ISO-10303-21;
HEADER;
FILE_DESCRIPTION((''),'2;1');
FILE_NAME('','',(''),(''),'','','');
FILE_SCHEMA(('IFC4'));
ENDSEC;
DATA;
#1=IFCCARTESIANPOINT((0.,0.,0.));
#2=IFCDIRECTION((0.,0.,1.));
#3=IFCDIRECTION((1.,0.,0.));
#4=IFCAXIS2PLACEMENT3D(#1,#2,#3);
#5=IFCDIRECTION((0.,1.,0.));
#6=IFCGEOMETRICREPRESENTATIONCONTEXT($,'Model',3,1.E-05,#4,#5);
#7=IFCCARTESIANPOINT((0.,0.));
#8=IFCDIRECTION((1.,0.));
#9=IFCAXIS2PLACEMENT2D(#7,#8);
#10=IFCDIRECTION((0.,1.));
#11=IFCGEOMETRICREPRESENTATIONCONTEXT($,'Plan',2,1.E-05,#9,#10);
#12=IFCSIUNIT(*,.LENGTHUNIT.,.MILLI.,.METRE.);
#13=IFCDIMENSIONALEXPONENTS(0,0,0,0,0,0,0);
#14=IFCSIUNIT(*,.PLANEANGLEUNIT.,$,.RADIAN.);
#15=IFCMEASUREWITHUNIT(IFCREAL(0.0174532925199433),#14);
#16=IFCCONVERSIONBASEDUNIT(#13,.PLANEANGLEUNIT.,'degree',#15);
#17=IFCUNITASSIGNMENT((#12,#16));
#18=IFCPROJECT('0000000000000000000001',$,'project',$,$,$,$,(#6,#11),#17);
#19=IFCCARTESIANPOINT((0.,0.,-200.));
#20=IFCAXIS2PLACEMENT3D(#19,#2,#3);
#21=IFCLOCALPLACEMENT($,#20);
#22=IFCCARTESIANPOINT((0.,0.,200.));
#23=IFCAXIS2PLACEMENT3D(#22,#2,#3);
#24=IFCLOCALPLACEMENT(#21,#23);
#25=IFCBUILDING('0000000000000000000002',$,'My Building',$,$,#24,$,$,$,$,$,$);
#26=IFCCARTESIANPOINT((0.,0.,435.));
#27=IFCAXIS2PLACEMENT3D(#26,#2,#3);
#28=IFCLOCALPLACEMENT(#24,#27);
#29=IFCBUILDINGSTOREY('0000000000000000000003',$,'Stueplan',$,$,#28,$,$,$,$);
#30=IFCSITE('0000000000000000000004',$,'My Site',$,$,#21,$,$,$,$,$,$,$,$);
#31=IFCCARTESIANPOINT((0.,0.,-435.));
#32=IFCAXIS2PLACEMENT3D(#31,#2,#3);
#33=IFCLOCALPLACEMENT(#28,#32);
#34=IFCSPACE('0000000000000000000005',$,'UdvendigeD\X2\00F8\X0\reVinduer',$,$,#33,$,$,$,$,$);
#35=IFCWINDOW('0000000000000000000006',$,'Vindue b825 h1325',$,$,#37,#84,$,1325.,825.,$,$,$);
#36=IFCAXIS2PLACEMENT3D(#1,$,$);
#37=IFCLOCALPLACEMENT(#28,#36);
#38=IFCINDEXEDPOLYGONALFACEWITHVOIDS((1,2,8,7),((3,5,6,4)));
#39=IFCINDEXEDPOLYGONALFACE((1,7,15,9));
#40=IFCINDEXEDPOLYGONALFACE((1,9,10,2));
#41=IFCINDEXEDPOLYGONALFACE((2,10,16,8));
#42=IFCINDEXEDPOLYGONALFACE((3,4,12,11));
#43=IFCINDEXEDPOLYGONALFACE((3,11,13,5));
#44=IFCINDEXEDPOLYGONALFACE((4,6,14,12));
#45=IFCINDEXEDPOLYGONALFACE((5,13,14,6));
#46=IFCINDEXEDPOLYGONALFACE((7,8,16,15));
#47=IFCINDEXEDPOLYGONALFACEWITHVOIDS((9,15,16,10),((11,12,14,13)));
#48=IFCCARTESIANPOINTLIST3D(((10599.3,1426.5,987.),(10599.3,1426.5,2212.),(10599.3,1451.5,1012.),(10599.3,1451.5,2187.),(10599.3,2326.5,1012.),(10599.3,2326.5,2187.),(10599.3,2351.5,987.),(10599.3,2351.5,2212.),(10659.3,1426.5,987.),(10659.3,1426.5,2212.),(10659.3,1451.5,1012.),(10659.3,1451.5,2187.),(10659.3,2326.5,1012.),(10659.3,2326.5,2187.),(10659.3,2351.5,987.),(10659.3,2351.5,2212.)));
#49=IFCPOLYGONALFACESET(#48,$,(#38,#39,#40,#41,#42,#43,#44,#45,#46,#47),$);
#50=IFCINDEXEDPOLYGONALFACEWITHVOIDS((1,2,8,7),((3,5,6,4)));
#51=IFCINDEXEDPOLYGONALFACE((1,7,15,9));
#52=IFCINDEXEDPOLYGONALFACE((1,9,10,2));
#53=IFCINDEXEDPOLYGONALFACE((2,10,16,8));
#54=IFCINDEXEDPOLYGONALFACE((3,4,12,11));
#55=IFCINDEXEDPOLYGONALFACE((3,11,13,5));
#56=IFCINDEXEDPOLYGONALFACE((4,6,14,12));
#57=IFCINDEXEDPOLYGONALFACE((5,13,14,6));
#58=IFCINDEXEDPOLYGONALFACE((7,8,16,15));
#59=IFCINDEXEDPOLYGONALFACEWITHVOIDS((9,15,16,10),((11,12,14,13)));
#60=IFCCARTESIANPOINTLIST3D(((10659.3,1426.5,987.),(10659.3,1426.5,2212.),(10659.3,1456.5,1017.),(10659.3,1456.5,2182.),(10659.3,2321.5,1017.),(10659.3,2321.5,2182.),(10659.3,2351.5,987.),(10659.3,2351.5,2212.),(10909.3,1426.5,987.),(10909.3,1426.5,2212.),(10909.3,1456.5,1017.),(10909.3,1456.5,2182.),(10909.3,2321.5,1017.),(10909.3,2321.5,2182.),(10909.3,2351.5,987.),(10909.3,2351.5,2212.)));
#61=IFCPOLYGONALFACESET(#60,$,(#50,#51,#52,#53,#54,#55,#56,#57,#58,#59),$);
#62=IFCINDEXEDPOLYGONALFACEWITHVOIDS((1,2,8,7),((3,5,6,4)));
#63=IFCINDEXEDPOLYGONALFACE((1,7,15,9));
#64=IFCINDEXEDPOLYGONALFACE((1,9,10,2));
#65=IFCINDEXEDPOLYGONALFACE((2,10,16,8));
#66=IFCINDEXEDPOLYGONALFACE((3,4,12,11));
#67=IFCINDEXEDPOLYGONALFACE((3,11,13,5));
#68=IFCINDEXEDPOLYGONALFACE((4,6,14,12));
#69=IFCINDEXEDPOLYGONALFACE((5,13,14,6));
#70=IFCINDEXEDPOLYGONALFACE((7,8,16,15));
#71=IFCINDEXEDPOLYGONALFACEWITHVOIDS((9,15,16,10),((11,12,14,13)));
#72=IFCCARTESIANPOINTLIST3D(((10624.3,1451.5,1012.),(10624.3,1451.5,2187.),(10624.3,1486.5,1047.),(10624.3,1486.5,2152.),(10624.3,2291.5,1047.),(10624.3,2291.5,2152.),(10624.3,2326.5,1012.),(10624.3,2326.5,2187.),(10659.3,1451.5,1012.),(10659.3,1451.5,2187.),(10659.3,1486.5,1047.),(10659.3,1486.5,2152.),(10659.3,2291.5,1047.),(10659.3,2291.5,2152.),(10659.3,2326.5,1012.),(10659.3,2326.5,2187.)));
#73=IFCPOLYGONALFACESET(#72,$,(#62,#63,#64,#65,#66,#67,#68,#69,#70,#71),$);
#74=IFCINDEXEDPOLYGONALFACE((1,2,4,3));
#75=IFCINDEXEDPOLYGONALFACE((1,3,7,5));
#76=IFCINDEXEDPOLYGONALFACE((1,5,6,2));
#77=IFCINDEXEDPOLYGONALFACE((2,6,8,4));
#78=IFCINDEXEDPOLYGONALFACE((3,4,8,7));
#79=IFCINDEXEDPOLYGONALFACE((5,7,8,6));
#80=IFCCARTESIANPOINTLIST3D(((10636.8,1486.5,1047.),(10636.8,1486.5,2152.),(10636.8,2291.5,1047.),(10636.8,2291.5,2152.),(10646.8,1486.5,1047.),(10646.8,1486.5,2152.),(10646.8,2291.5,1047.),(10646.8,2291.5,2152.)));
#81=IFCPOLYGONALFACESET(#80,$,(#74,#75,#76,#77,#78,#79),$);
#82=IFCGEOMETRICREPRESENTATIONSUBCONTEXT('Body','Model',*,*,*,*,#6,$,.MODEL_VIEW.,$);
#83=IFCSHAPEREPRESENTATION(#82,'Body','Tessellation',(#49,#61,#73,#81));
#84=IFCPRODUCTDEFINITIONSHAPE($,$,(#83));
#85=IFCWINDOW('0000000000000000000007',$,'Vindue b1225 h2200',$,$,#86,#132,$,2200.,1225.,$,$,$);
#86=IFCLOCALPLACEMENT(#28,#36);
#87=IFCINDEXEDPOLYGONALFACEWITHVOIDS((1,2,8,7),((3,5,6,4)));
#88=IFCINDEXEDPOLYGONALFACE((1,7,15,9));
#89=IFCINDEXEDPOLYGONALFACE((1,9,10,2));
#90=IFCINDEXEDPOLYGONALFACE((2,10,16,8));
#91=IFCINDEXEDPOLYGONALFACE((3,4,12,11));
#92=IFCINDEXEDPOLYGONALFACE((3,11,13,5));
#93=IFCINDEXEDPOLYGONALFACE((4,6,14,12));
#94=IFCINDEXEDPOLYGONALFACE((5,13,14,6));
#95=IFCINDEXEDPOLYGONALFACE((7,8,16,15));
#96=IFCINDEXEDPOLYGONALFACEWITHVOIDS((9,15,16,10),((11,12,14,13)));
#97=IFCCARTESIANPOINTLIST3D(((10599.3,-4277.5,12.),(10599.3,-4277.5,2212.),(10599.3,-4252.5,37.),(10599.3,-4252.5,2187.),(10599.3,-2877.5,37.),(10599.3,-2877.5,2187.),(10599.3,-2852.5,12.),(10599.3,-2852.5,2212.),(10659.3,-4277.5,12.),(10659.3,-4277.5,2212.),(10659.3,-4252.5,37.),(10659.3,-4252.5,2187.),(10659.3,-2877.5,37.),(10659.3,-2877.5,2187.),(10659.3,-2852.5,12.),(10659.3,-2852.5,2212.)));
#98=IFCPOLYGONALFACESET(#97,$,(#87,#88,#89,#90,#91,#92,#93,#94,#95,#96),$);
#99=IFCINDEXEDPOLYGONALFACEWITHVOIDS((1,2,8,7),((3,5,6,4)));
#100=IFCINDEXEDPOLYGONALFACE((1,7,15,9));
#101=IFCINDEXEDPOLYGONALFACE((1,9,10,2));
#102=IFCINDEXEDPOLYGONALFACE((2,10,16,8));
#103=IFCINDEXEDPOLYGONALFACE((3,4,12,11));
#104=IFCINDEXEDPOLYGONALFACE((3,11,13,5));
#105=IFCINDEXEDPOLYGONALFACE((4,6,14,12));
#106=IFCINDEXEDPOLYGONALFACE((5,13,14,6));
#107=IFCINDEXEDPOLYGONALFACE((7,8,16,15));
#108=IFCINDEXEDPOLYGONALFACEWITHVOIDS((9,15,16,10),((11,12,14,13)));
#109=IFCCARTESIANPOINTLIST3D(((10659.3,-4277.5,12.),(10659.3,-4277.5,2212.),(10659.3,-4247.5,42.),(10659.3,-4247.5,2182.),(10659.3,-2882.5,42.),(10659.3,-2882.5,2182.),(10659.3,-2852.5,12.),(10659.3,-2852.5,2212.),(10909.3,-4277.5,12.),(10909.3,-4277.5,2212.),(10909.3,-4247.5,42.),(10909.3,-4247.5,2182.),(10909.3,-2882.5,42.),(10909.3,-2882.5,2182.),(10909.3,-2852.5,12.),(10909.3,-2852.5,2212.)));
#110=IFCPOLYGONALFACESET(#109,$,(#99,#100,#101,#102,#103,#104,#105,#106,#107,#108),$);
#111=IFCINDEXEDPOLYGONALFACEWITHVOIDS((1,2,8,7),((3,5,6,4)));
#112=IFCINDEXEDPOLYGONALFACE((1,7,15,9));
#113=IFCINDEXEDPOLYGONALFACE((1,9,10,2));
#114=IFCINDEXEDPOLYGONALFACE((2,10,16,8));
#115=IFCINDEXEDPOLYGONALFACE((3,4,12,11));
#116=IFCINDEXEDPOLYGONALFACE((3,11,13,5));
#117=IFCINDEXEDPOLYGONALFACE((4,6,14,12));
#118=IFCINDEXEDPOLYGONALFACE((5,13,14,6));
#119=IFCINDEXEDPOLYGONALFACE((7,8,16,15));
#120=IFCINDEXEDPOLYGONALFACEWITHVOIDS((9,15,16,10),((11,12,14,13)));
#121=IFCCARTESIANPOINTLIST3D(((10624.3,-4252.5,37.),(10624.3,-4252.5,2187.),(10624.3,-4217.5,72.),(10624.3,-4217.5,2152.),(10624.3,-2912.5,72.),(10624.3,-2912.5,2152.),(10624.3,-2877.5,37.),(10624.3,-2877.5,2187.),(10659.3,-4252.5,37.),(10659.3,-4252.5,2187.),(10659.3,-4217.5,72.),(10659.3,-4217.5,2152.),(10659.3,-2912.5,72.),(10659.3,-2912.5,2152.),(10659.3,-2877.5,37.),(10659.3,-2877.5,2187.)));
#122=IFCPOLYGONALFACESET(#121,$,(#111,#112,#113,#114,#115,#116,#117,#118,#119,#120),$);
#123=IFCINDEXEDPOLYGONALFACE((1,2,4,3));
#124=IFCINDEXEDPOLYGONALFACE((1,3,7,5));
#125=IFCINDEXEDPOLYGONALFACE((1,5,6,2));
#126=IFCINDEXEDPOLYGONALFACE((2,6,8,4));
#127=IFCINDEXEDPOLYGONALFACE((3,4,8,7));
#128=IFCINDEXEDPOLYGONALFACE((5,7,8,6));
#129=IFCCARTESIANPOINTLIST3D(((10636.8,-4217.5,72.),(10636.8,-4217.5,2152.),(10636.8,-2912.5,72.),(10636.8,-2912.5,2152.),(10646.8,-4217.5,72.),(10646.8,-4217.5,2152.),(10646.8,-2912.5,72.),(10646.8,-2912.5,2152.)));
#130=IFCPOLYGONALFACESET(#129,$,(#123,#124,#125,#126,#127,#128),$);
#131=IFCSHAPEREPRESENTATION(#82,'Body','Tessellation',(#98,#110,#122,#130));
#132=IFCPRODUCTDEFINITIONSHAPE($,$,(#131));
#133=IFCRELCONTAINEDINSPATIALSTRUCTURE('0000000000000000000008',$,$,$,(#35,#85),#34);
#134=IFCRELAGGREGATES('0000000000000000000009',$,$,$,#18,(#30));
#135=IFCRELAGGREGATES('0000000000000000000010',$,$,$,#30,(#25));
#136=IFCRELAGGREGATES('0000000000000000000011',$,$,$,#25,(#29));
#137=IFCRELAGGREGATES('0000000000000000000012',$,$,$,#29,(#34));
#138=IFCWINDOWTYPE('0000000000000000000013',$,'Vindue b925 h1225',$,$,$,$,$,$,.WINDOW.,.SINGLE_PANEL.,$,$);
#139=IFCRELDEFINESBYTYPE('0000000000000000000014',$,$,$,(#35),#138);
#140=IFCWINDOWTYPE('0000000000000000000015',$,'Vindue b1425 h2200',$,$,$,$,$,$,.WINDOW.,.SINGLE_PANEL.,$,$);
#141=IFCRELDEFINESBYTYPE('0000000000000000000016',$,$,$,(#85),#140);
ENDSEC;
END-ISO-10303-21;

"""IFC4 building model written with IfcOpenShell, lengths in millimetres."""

from ifc_helpers import new_model, entity, si_unit, converted_unit, direction, frame, origin_with_axes, origin_2d_with_axis, place, context, subcontext, project, spatial, line, indexed_curve, outline, extrude, shape, source, transform, mapped, type_object, type_shapes, element, save


model = new_model("IFC4")

# Units and contexts
model_context = context("Model", 3, precision=1e-05, world=origin_with_axes(), true_north=direction((0.0, 1.0, 0.0)))
plan_context = context("Plan", 2, precision=1e-05, world=origin_2d_with_axis(), true_north=direction((0.0, 1.0)))
body_context_1 = subcontext(model_context, "Body", "Model", "MODEL_VIEW")
body_context_2 = subcontext(plan_context, "Body", "Plan", "PLAN_VIEW")
ifc_project = project(units=[si_unit("LENGTHUNIT", "METRE", prefix="MILLI"), converted_unit("PLANEANGLEUNIT", "degree", entity("IfcReal", 0.0174532925199433), si_unit("PLANEANGLEUNIT", "RADIAN"), dimensions=[0, 0, 0, 0, 0, 0, 0])], contexts=[model_context, plan_context])

# Site, building, storey
site_placement = place(None, frame((0.0, 0.0, -200.0), z_axis=(0.0, 0.0, 1.0), x_axis=(1.0, 0.0, 0.0)))
site = spatial("IfcSite", under=ifc_project, at=site_placement, Name="My Site")
building_placement = place(site_placement, frame((0.0, 0.0, 200.0), z_axis=(0.0, 0.0, 1.0), x_axis=(1.0, 0.0, 0.0)))
building = spatial("IfcBuilding", under=site, at=building_placement, Name="My Building")
storey_placement = place(building_placement, frame((0.0, 0.0, 435.0), z_axis=(0.0, 0.0, 1.0), x_axis=(1.0, 0.0, 0.0)))
storey = spatial("IfcBuildingStorey", under=building, at=storey_placement, Name="Stueplan")

# Shared definitions
space_1_placement = place(storey_placement, frame((0.0, 0.0, -435.0), z_axis=(0.0, 0.0, 1.0), x_axis=(1.0, 0.0, 0.0)))
space_1 = spatial("IfcSpace", under=storey, at=space_1_placement, Name="UdvendigeDøreVinduer")

# Windows
window_type_1 = type_object("IfcWindowType", Name="Vindue b925 h1225", PartitioningType="SINGLE_PANEL", PredefinedType="WINDOW")
shared_shape_1 = source(origin_with_axes(), body_context_1, "Body", "SweptSolid", [
    extrude(outline(indexed_curve([(0.0, 0.0), (925.0, 0.0), (925.0, 1225.0), (0.0, 1225.0)], segments=[line(1, 2, 3, 4, 1)]), holes=[indexed_curve([(25.0, 25.0), (900.0, 25.0), (900.0, 1200.0), (25.0, 1200.0)], segments=[line(1, 2, 3, 4, 1)])]), frame((0.0, 250.0, 0.0), z_axis=(0.0, -1.0, 0.0), x_axis=(1.0, 0.0, 0.0)), (0.0, 0.0, -1.0), 60.0),
    extrude(outline(indexed_curve([(0.0, 0.0), (925.0, 0.0), (925.0, 1225.0), (0.0, 1225.0)], segments=[line(1, 2, 3, 4, 1)]), holes=[indexed_curve([(30.0, 30.0), (895.0, 30.0), (895.0, 1195.0), (30.0, 1195.0)], segments=[line(1, 2, 3, 4, 1)])]), frame((0.0, 0.0, 0.0), z_axis=(0.0, -1.0, 0.0), x_axis=(1.0, 0.0, 0.0)), (0.0, 0.0, -1.0), 250.0),
    extrude(outline(indexed_curve([(0.0, 0.0), (875.0, 0.0), (875.0, 1175.0), (0.0, 1175.0)], segments=[line(1, 2, 3, 4, 1)]), holes=[indexed_curve([(35.0, 35.0), (840.0, 35.0), (840.0, 1140.0), (35.0, 1140.0)], segments=[line(1, 2, 3, 4, 1)])]), frame((25.0, 250.0, 25.0), z_axis=(0.0, -1.0, 0.0), x_axis=(1.0, 0.0, 0.0)), (0.0, 0.0, -1.0), 35.0),
    extrude(outline(indexed_curve([(35.0, 35.0), (840.0, 35.0), (840.0, 1140.0), (35.0, 1140.0)], segments=[line(1, 2, 3, 4, 1)])), frame((25.0, 262.5, 25.0), z_axis=(0.0, -1.0, 0.0), x_axis=(1.0, 0.0, 0.0)), (0.0, 0.0, -1.0), 10.0),
])
shared_shape_2 = source(origin_with_axes(), body_context_2, "Body", "Curve2D", [
    entity("IfcIndexedPolyCurve", entity("IfcCartesianPointList2D", [[30.0, 0.0], [895.0, 0.0]])),
    entity("IfcIndexedPolyCurve", entity("IfcCartesianPointList2D", [[0.0, 310.0], [25.0, 310.0], [25.0, 250.0], [30.0, 250.0], [30.0, 0.0], [0.0, 0.0]]), [entity("IfcLineIndex", [1, 2, 3, 4, 5, 6, 1])]),
    entity("IfcIndexedPolyCurve", entity("IfcCartesianPointList2D", [[925.0, 310.0], [900.0, 310.0], [900.0, 250.0], [895.0, 250.0], [895.0, 0.0], [925.0, 0.0]]), [entity("IfcLineIndex", [1, 2, 3, 4, 5, 6, 1])]),
    entity("IfcIndexedPolyCurve", entity("IfcCartesianPointList2D", [[25.0, 250.0], [60.0, 250.0], [60.0, 285.0], [25.0, 285.0]]), [entity("IfcLineIndex", [1, 2, 3, 4, 1])]),
    entity("IfcIndexedPolyCurve", entity("IfcCartesianPointList2D", [[900.0, 250.0], [865.0, 250.0], [865.0, 285.0], [900.0, 285.0]]), [entity("IfcLineIndex", [1, 2, 3, 4, 1])]),
    entity("IfcIndexedPolyCurve", entity("IfcCartesianPointList2D", [[60.0, 250.0], [865.0, 250.0]])),
    entity("IfcIndexedPolyCurve", entity("IfcCartesianPointList2D", [[60.0, 285.0], [865.0, 285.0]])),
    entity("IfcIndexedPolyCurve", entity("IfcCartesianPointList2D", [[60.0, 267.5], [865.0, 267.5]])),
])
type_shapes(window_type_1, [shared_shape_1, shared_shape_2])
window_1_placement = place(space_1_placement, frame((10909.3, 1426.5, 1422.0), z_axis=(0.0, 0.0, 1.0), x_axis=(0.0, 1.0, 0.0)))
element("IfcWindow", 1, at=window_1_placement, inside=space_1, type_object=window_type_1, Name="Vindue b825 h1325", OverallHeight=1325.0, OverallWidth=825.0, shapes=[
    shape(body_context_1, "Body", "MappedRepresentation", [mapped(shared_shape_1, transform((0.0, 0.0, 0.0), x_axis=(1.0, 0.0, 0.0), y_axis=(0.0, 1.0, 0.0), z_axis=(0.0, 0.0, 1.0), scale=1.0))]),
    shape(body_context_2, "Body", "MappedRepresentation", [mapped(shared_shape_2, transform((0.0, 0.0, 0.0), x_axis=(1.0, 0.0, 0.0), y_axis=(0.0, 1.0, 0.0), z_axis=(0.0, 0.0, 1.0), scale=1.0))]),
])
window_type_2 = type_object("IfcWindowType", Name="Vindue b1425 h2200", PartitioningType="SINGLE_PANEL", PredefinedType="WINDOW")
shared_shape_3 = source(origin_with_axes(), body_context_1, "Body", "SweptSolid", [
    extrude(outline(indexed_curve([(0.0, 0.0), (1425.0, 0.0), (1425.0, 2200.0), (0.0, 2200.0)], segments=[line(1, 2, 3, 4, 1)]), holes=[indexed_curve([(25.0, 25.0), (1400.0, 25.0), (1400.0, 2175.0), (25.0, 2175.0)], segments=[line(1, 2, 3, 4, 1)])]), frame((0.0, 250.0, 0.0), z_axis=(0.0, -1.0, 0.0), x_axis=(1.0, 0.0, 0.0)), (0.0, 0.0, -1.0), 60.0),
    extrude(outline(indexed_curve([(0.0, 0.0), (1425.0, 0.0), (1425.0, 2200.0), (0.0, 2200.0)], segments=[line(1, 2, 3, 4, 1)]), holes=[indexed_curve([(30.0, 30.0), (1395.0, 30.0), (1395.0, 2170.0), (30.0, 2170.0)], segments=[line(1, 2, 3, 4, 1)])]), frame((0.0, 0.0, 0.0), z_axis=(0.0, -1.0, 0.0), x_axis=(1.0, 0.0, 0.0)), (0.0, 0.0, -1.0), 250.0),
    extrude(outline(indexed_curve([(0.0, 0.0), (1375.0, 0.0), (1375.0, 2150.0), (0.0, 2150.0)], segments=[line(1, 2, 3, 4, 1)]), holes=[indexed_curve([(35.0, 35.0), (1340.0, 35.0), (1340.0, 2115.0), (35.0, 2115.0)], segments=[line(1, 2, 3, 4, 1)])]), frame((25.0, 250.0, 25.0), z_axis=(0.0, -1.0, 0.0), x_axis=(1.0, 0.0, 0.0)), (0.0, 0.0, -1.0), 35.0),
    extrude(outline(indexed_curve([(35.0, 35.0), (1340.0, 35.0), (1340.0, 2115.0), (35.0, 2115.0)], segments=[line(1, 2, 3, 4, 1)])), frame((25.0, 262.5, 25.0), z_axis=(0.0, -1.0, 0.0), x_axis=(1.0, 0.0, 0.0)), (0.0, 0.0, -1.0), 10.0),
])
shared_shape_4 = source(origin_with_axes(), body_context_2, "Body", "Curve2D", [
    entity("IfcIndexedPolyCurve", entity("IfcCartesianPointList2D", [[30.0, 0.0], [1395.0, 0.0]])),
    entity("IfcIndexedPolyCurve", entity("IfcCartesianPointList2D", [[0.0, 310.0], [25.0, 310.0], [25.0, 250.0], [30.0, 250.0], [30.0, 0.0], [0.0, 0.0]]), [entity("IfcLineIndex", [1, 2, 3, 4, 5, 6, 1])]),
    entity("IfcIndexedPolyCurve", entity("IfcCartesianPointList2D", [[1425.0, 310.0], [1400.0, 310.0], [1400.0, 250.0], [1395.0, 250.0], [1395.0, 0.0], [1425.0, 0.0]]), [entity("IfcLineIndex", [1, 2, 3, 4, 5, 6, 1])]),
    entity("IfcIndexedPolyCurve", entity("IfcCartesianPointList2D", [[25.0, 250.0], [60.0, 250.0], [60.0, 285.0], [25.0, 285.0]]), [entity("IfcLineIndex", [1, 2, 3, 4, 1])]),
    entity("IfcIndexedPolyCurve", entity("IfcCartesianPointList2D", [[1400.0, 250.0], [1365.0, 250.0], [1365.0, 285.0], [1400.0, 285.0]]), [entity("IfcLineIndex", [1, 2, 3, 4, 1])]),
    entity("IfcIndexedPolyCurve", entity("IfcCartesianPointList2D", [[60.0, 250.0], [1365.0, 250.0]])),
    entity("IfcIndexedPolyCurve", entity("IfcCartesianPointList2D", [[60.0, 285.0], [1365.0, 285.0]])),
    entity("IfcIndexedPolyCurve", entity("IfcCartesianPointList2D", [[60.0, 267.5], [1365.0, 267.5]])),
])
type_shapes(window_type_2, [shared_shape_3, shared_shape_4])
window_2_placement = place(space_1_placement, frame((10909.3, -4277.5, 447.0), z_axis=(0.0, 0.0, 1.0), x_axis=(0.0, 1.0, 0.0)))
element("IfcWindow", 2, at=window_2_placement, inside=space_1, type_object=window_type_2, Name="Vindue b1225 h2200", OverallHeight=2200.0, OverallWidth=1225.0, shapes=[
    shape(body_context_1, "Body", "MappedRepresentation", [mapped(shared_shape_3, transform((0.0, 0.0, 0.0), x_axis=(1.0, 0.0, 0.0), y_axis=(0.0, 1.0, 0.0), z_axis=(0.0, 0.0, 1.0), scale=1.0))]),
    shape(body_context_2, "Body", "MappedRepresentation", [mapped(shared_shape_4, transform((0.0, 0.0, 0.0), x_axis=(1.0, 0.0, 0.0), y_axis=(0.0, 1.0, 0.0), z_axis=(0.0, 0.0, 1.0), scale=1.0))]),
])

save(model, "model.ifc")
